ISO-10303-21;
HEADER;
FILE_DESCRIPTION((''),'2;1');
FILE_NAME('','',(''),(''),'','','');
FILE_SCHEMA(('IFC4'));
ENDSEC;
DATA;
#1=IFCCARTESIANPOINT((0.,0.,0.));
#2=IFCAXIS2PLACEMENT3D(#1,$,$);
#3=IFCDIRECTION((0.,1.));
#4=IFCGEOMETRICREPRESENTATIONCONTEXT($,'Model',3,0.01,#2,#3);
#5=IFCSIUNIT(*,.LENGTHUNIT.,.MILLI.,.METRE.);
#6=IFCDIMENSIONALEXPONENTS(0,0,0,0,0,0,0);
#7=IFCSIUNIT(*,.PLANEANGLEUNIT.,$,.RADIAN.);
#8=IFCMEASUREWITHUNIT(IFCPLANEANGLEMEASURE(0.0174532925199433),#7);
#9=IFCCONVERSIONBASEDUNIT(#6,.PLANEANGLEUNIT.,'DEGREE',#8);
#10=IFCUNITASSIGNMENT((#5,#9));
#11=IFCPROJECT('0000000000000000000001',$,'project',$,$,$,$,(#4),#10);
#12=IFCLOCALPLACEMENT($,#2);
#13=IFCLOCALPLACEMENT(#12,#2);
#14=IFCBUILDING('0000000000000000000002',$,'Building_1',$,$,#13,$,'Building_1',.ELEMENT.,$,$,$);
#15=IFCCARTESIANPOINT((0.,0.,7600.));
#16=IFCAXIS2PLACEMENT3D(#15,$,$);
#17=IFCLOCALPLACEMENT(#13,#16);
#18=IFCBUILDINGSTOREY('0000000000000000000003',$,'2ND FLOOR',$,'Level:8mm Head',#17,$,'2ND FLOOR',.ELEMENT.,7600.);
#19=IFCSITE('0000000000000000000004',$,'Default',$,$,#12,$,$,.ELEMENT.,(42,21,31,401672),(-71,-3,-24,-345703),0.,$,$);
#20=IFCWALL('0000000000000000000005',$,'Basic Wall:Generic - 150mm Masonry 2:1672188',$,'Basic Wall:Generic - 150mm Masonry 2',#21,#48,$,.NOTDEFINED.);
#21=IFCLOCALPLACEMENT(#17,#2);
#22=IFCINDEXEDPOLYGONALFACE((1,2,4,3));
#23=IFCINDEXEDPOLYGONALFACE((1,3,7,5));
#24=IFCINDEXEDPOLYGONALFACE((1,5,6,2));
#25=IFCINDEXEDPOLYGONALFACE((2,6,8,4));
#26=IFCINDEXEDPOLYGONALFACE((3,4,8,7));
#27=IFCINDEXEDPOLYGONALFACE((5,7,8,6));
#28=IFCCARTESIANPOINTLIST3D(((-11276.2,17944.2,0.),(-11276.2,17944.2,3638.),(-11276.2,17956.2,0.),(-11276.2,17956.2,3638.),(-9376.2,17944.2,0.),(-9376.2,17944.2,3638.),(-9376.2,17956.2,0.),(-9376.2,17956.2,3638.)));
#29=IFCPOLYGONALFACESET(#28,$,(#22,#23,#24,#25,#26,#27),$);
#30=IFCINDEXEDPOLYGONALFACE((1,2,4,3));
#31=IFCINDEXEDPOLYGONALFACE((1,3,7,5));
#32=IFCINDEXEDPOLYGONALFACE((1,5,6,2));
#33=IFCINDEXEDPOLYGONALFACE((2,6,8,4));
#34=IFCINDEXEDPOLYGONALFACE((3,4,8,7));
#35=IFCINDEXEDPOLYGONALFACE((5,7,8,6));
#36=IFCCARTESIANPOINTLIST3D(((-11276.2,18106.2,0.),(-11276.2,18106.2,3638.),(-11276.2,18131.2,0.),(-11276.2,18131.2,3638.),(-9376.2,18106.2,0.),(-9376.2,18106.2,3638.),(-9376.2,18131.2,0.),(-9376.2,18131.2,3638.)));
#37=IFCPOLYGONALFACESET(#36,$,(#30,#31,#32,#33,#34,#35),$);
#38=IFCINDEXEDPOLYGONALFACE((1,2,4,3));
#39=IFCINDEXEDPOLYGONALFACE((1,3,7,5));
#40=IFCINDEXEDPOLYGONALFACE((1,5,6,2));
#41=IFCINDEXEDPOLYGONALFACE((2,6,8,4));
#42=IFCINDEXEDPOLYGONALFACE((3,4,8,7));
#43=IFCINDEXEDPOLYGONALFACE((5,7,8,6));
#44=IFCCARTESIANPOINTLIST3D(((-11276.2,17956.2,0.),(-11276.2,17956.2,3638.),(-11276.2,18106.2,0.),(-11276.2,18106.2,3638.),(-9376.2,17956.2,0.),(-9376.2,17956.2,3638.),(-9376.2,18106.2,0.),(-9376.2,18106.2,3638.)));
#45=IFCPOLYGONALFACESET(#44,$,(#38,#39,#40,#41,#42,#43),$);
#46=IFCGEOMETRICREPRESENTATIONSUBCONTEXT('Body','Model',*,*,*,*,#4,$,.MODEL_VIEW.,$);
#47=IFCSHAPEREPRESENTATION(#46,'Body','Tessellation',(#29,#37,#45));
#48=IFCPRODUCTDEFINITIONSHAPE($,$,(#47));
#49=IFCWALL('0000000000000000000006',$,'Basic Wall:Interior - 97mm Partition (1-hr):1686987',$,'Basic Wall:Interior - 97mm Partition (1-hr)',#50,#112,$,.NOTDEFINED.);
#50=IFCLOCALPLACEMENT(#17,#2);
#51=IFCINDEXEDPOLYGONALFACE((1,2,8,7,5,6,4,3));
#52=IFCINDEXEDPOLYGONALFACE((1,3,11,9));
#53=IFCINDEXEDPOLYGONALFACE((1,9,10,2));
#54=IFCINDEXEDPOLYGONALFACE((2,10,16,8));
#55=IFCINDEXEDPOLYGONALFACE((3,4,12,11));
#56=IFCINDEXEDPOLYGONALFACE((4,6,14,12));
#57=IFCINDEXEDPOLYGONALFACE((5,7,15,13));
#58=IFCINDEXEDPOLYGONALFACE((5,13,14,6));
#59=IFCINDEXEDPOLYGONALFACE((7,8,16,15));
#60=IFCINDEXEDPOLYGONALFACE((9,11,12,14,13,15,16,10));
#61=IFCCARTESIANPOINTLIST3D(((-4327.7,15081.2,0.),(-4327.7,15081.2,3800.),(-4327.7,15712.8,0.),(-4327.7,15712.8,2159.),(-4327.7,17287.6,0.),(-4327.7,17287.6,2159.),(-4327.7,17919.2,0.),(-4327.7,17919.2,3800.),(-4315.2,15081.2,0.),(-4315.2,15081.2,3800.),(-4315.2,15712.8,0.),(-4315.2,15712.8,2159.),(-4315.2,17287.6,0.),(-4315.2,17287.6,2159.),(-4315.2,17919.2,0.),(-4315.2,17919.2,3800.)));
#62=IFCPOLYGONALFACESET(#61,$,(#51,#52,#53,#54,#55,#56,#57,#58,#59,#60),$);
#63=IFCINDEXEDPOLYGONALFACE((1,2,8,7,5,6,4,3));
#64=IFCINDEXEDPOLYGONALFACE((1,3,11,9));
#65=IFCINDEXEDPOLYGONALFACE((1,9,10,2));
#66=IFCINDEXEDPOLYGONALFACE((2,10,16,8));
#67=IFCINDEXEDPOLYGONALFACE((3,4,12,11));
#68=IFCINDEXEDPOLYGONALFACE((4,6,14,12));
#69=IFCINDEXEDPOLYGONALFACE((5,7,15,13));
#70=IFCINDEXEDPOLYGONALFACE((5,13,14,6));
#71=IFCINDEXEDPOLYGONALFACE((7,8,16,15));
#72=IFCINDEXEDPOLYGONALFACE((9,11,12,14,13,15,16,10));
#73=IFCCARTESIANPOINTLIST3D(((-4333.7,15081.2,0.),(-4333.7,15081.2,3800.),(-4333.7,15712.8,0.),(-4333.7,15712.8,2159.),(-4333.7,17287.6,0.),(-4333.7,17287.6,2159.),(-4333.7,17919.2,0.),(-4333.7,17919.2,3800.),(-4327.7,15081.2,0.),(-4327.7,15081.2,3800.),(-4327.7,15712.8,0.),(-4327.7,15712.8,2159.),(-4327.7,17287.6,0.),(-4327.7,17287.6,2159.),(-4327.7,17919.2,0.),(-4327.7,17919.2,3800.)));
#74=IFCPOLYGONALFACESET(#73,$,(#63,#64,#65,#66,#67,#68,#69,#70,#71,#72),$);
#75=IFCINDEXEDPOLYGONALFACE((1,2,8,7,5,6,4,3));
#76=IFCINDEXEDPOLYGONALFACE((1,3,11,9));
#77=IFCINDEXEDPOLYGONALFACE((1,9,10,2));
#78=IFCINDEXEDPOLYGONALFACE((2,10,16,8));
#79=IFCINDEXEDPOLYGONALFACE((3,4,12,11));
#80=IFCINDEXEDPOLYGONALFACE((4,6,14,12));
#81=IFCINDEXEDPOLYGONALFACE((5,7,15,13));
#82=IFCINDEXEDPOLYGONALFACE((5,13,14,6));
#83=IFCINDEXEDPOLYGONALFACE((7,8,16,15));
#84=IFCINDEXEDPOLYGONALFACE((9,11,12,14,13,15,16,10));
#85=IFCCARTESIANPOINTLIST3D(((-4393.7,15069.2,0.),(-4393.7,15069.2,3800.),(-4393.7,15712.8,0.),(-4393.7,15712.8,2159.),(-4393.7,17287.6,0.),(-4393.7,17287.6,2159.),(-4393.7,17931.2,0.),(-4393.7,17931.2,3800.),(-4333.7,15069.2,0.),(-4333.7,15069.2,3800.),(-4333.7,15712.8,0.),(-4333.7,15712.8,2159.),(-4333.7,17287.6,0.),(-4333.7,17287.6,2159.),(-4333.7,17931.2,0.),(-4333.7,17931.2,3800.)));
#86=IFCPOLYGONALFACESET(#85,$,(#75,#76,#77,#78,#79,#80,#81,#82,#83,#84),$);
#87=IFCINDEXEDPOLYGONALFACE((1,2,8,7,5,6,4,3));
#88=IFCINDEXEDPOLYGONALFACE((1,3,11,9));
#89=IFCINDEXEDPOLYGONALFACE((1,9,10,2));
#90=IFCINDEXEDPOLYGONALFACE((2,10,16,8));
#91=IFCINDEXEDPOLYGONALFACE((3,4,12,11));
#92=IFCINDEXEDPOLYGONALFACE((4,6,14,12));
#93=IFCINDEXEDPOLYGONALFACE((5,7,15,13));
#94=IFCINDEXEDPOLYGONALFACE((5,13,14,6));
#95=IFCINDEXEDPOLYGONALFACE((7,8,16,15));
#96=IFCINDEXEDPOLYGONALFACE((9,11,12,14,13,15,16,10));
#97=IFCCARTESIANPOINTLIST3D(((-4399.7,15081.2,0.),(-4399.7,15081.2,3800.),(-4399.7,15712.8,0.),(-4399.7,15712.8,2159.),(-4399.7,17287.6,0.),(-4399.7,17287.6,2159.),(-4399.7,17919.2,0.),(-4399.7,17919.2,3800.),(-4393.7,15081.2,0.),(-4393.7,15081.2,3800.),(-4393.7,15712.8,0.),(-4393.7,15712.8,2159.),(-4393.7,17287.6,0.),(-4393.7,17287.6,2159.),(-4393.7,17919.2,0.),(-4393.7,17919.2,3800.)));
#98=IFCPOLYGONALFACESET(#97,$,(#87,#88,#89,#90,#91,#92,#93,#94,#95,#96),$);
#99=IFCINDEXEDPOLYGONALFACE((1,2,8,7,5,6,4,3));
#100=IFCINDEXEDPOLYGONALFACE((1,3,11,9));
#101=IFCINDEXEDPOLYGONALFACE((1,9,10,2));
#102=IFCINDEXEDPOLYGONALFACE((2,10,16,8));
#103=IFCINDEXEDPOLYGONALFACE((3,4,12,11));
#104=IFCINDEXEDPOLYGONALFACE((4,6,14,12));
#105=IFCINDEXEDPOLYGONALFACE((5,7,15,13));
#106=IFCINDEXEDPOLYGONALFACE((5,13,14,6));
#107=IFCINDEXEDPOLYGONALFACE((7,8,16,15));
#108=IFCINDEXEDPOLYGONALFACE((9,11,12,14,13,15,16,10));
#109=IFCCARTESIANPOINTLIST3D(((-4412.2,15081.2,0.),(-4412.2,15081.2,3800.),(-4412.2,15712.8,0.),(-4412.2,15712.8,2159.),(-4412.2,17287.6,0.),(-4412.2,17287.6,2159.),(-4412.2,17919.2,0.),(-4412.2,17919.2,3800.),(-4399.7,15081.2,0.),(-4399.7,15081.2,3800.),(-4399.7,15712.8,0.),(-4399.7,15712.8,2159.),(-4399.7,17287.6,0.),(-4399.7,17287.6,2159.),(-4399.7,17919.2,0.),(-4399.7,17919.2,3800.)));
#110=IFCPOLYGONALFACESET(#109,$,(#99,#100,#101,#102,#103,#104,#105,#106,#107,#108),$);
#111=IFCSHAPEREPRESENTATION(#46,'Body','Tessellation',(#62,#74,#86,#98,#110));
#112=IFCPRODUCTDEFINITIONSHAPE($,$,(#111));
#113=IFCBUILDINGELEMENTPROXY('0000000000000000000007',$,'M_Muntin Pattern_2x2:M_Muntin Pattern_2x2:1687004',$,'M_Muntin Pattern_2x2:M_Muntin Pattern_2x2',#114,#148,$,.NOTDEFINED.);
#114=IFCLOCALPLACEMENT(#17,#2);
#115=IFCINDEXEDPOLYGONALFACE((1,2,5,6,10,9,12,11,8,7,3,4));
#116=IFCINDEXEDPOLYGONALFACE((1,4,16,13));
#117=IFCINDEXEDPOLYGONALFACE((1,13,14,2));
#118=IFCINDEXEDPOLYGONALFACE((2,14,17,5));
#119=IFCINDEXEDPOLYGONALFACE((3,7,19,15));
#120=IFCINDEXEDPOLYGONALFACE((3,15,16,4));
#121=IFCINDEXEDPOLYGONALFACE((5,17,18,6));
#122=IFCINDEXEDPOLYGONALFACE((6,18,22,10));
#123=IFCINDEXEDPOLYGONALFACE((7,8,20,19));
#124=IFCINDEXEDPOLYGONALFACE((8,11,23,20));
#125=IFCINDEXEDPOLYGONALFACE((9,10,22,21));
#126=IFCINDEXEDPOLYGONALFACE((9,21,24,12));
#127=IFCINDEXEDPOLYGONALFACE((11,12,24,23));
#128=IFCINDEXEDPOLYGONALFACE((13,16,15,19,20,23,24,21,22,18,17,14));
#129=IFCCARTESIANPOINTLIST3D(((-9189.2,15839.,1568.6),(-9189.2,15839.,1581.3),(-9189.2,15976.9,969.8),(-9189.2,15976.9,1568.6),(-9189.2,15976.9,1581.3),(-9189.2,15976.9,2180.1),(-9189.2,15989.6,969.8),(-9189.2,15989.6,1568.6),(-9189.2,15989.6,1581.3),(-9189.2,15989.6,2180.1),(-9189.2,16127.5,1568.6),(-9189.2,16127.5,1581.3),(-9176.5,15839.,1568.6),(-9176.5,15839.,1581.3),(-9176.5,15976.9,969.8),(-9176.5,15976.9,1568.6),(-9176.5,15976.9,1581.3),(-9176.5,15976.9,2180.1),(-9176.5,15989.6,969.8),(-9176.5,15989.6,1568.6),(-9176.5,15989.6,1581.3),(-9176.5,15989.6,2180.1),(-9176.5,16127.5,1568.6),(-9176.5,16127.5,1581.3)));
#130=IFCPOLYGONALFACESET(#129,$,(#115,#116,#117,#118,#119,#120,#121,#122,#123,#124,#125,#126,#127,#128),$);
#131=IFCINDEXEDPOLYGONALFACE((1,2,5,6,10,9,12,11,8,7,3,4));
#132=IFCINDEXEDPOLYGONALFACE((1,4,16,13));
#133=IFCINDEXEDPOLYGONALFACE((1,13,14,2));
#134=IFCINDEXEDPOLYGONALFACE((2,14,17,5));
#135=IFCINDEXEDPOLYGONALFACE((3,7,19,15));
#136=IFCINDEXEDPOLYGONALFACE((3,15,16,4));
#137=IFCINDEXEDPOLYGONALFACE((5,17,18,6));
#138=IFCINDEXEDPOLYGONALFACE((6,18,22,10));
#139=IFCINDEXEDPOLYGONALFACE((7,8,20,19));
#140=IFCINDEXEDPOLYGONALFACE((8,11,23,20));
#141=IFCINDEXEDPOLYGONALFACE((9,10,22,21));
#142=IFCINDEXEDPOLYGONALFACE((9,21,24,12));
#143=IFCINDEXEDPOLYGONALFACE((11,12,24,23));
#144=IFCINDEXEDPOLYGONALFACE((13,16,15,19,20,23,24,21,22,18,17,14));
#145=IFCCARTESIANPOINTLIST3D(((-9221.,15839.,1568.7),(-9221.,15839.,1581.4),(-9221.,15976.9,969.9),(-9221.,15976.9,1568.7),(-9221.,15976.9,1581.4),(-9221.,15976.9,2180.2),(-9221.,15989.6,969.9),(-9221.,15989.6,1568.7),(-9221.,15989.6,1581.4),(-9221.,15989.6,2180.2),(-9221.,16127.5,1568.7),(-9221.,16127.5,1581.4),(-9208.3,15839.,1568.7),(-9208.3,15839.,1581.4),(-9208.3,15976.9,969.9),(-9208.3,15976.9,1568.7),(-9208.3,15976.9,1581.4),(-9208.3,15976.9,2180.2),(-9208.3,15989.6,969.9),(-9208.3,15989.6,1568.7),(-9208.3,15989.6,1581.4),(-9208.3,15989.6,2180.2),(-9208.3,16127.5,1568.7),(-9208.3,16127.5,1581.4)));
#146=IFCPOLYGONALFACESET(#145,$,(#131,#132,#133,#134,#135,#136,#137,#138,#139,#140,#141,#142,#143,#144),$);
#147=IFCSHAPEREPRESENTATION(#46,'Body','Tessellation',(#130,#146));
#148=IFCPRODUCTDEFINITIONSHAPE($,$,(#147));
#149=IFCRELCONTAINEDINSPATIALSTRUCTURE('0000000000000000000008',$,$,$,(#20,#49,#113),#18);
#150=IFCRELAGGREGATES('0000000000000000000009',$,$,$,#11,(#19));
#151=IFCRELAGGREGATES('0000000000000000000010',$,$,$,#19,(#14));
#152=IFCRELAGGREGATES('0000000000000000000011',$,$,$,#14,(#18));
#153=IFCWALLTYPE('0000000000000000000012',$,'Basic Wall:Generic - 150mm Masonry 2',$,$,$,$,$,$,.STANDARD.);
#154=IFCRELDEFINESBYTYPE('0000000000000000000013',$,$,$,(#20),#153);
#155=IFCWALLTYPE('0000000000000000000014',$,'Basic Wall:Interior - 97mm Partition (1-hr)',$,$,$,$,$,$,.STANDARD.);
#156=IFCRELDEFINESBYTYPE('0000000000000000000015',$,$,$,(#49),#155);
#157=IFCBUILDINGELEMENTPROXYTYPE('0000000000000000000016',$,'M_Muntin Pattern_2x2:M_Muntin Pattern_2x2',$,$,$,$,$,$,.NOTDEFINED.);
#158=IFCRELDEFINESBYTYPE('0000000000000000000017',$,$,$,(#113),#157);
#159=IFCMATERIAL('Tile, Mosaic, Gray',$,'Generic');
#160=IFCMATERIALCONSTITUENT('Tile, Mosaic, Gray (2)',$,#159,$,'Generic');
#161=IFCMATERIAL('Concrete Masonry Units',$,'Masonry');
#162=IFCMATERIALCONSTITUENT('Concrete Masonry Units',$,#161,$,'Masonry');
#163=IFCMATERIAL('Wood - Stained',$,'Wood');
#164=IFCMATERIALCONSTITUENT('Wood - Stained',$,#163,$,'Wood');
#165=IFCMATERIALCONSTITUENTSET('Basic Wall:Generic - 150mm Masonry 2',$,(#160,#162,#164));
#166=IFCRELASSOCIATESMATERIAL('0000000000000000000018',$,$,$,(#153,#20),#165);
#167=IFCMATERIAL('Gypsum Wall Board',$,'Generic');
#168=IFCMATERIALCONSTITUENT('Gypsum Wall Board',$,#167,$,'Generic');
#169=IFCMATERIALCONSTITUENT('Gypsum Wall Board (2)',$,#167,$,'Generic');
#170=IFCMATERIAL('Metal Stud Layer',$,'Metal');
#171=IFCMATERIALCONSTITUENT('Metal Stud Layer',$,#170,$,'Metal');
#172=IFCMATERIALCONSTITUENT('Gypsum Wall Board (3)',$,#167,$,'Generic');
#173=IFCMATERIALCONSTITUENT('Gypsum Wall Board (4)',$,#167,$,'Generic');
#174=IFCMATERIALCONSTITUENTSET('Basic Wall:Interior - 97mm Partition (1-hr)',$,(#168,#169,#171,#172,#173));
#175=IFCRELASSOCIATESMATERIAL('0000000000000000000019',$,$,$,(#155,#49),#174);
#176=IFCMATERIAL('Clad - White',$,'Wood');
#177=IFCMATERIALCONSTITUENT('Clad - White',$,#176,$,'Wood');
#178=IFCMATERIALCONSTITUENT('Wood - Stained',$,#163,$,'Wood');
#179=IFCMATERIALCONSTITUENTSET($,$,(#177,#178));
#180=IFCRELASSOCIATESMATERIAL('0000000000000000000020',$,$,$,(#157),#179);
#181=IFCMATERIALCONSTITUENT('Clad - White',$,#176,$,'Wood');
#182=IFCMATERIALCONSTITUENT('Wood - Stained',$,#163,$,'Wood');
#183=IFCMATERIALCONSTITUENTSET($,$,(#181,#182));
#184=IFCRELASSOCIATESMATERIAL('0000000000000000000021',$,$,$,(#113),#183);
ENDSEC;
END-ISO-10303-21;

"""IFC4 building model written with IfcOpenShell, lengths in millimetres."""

from ifc_helpers import new_model, entity, si_unit, converted_unit, direction, frame, origin, place, context, subcontext, project, spatial, indexed_curve, outline, extrude, source, transform, mapped, material, constituent, constituent_set, type_object, type_shapes, element, save


model = new_model("IFC4")

# Units and contexts
model_context = context("Model", 3, precision=0.01, world=origin(), true_north=direction((0.0, 1.0)))
body_context = subcontext(model_context, "Body", "Model", "MODEL_VIEW")
ifc_project = project(units=[si_unit("LENGTHUNIT", "METRE", prefix="MILLI"), converted_unit("PLANEANGLEUNIT", "DEGREE", entity("IfcPlaneAngleMeasure", 0.0174532925199433), si_unit("PLANEANGLEUNIT", "RADIAN"), dimensions=[0, 0, 0, 0, 0, 0, 0])], contexts=[model_context])

# Site, building, storey
site_placement = place(None, origin())
site = spatial("IfcSite", under=ifc_project, at=site_placement, Name="Default", CompositionType="ELEMENT", RefLatitude=(42, 21, 31, 401672), RefLongitude=(-71, -3, -24, -345703), RefElevation=0.0)
building_placement = place(site_placement, origin())
building = spatial("IfcBuilding", under=site, at=building_placement, Name="Building_1", LongName="Building_1", CompositionType="ELEMENT")
storey_placement = place(building_placement, frame((0.0, 0.0, 7600.0)))
storey = spatial("IfcBuildingStorey", under=building, at=storey_placement, Name="2ND FLOOR", ObjectType="Level:8mm Head", LongName="2ND FLOOR", CompositionType="ELEMENT", Elevation=7600.0)

# Shared definitions
ifc_material_1 = material(Name="Tile, Mosaic, Gray", Category="Generic")
ifc_constituent_1 = constituent(ifc_material_1, Name="Tile, Mosaic, Gray (2)", Category="Generic")
ifc_material_2 = material(Name="Concrete Masonry Units", Category="Masonry")
ifc_constituent_2 = constituent(ifc_material_2, Name="Concrete Masonry Units", Category="Masonry")
ifc_material_3 = material(Name="Wood - Stained", Category="Wood")
ifc_constituent_3 = constituent(ifc_material_3, Name="Wood - Stained", Category="Wood")
ifc_constituent_set_1 = constituent_set(constituents=[ifc_constituent_1, ifc_constituent_2, ifc_constituent_3], Name="Basic Wall:Generic - 150mm Masonry 2")
wall_type_1 = type_object("IfcWallType", Name="Basic Wall:Generic - 150mm Masonry 2", PredefinedType="STANDARD", material=ifc_constituent_set_1)

# Wall
wall_1_placement = place(storey_placement, frame((-11276.2, 18037.7, 0.0)))
element("IfcWall", 1, at=wall_1_placement, inside=storey, type_object=wall_type_1, material=ifc_constituent_set_1, Name="Basic Wall:Generic - 150mm Masonry 2:1672188", ObjectType="Basic Wall:Generic - 150mm Masonry 2", PredefinedType="NOTDEFINED", context=body_context, shape_type="SweptSolid", body=[
    extrude(outline(indexed_curve([(-6.0, -950.0), (6.0, -950.0), (6.0, 950.0), (-6.0, 950.0), (-6.0, -950.0)], self_intersect=False)), frame((950.0, -87.5, 0.0), z_axis=(0.0, 0.0, 1.0), x_axis=(0.0, 1.0, 0.0)), (0.0, 0.0, 1.0), 3638.0),
    extrude(outline(indexed_curve([(-12.5, -950.0), (12.5, -950.0), (12.5, 950.0), (-12.5, 950.0), (-12.5, -950.0)], self_intersect=False)), frame((950.0, 81.0, 0.0), z_axis=(0.0, 0.0, 1.0), x_axis=(0.0, -1.0, 0.0)), (0.0, 0.0, 1.0), 3638.0),
    extrude(outline(indexed_curve([(-950.0, -75.0), (950.0, -75.0), (950.0, 75.0), (-950.0, 75.0), (-950.0, -75.0)], self_intersect=False)), frame((950.0, -6.5, 0.0)), (0.0, 0.0, 1.0), 3638.0),
])

# Wall, opening
ifc_material_4 = material(Name="Gypsum Wall Board", Category="Generic")
ifc_constituent_4 = constituent(ifc_material_4, Name="Gypsum Wall Board", Category="Generic")
ifc_constituent_5 = constituent(ifc_material_4, Name="Gypsum Wall Board (2)", Category="Generic")
ifc_material_5 = material(Name="Metal Stud Layer", Category="Metal")
ifc_constituent_6 = constituent(ifc_material_5, Name="Metal Stud Layer", Category="Metal")
ifc_constituent_7 = constituent(ifc_material_4, Name="Gypsum Wall Board (3)", Category="Generic")
ifc_constituent_8 = constituent(ifc_material_4, Name="Gypsum Wall Board (4)", Category="Generic")
ifc_constituent_set_2 = constituent_set(constituents=[ifc_constituent_4, ifc_constituent_5, ifc_constituent_6, ifc_constituent_7, ifc_constituent_8], Name="Basic Wall:Interior - 97mm Partition (1-hr)")
wall_type_2 = type_object("IfcWallType", Name="Basic Wall:Interior - 97mm Partition (1-hr)", PredefinedType="STANDARD", material=ifc_constituent_set_2)
wall_2_placement = place(storey_placement, frame((-4363.7, 15081.2, 0.0), z_axis=(0.0, 0.0, 1.0), x_axis=(0.0, 1.0, 0.0)))
wall_2 = element("IfcWall", 2, at=wall_2_placement, inside=storey, type_object=wall_type_2, material=ifc_constituent_set_2, Name="Basic Wall:Interior - 97mm Partition (1-hr):1686987", ObjectType="Basic Wall:Interior - 97mm Partition (1-hr)", PredefinedType="NOTDEFINED", context=body_context, shape_type="SweptSolid", body=[
    extrude(outline(indexed_curve([(-1489.8, -1419.0), (2310.2, -1419.0), (2310.2, 1419.0), (-1489.8, 1419.0), (-1489.8, 787.4), (669.2, 787.4), (669.2, -787.4), (-1489.8, -787.4), (-1489.8, -1419.0)], self_intersect=False)), frame((1419.0, -36.0, 1489.8), z_axis=(0.0, -1.0, 0.0), x_axis=(0.0, 0.0, 1.0)), (0.0, 0.0, 1.0), 12.5),
    extrude(outline(indexed_curve([(-1489.8, -1419.0), (2310.2, -1419.0), (2310.2, 1419.0), (-1489.8, 1419.0), (-1489.8, 787.4), (669.2, 787.4), (669.2, -787.4), (-1489.8, -787.4), (-1489.8, -1419.0)], self_intersect=False)), frame((1419.0, -30.0, 1489.8), z_axis=(0.0, -1.0, 0.0), x_axis=(0.0, 0.0, 1.0)), (0.0, 0.0, 1.0), 6.0),
    extrude(outline(indexed_curve([(-1489.8, -1431.0), (2310.2, -1431.0), (2310.2, 1431.0), (-1489.8, 1431.0), (-1489.8, 787.4), (669.2, 787.4), (669.2, -787.4), (-1489.8, -787.4), (-1489.8, -1431.0)], self_intersect=False)), frame((1419.0, 30.0, 1489.8), z_axis=(0.0, -1.0, 0.0), x_axis=(0.0, 0.0, 1.0)), (0.0, 0.0, 1.0), 60.0),
    extrude(outline(indexed_curve([(-1489.8, -1419.0), (2310.2, -1419.0), (2310.2, 1419.0), (-1489.8, 1419.0), (-1489.8, 787.4), (669.2, 787.4), (669.2, -787.4), (-1489.8, -787.4), (-1489.8, -1419.0)], self_intersect=False)), frame((1419.0, 36.0, 1489.8), z_axis=(0.0, -1.0, 0.0), x_axis=(0.0, 0.0, 1.0)), (0.0, 0.0, 1.0), 6.0),
    extrude(outline(indexed_curve([(-2310.2, -1419.0), (1489.8, -1419.0), (1489.8, -787.4), (-669.2, -787.4), (-669.2, 787.4), (1489.8, 787.4), (1489.8, 1419.0), (-2310.2, 1419.0), (-2310.2, -1419.0)], self_intersect=False)), frame((1419.0, 48.5, 1489.8), z_axis=(0.0, -1.0, 0.0), x_axis=(0.0, 0.0, -1.0)), (0.0, 0.0, 1.0), 12.5),
])
opening_1_placement = place(wall_2_placement, frame((2206.4, 48.5, 0.0)))
element("IfcOpeningElement", 3, at=opening_1_placement, cuts=wall_2, PredefinedType="OPENING", context=body_context, shape_type="SweptSolid", body=[
    extrude(outline(indexed_curve([(0.0, 1574.8), (0.0, 0.0), (2159.0, 0.0), (2159.0, 1574.8), (0.0, 1574.8)], self_intersect=False)), frame((0.0, 0.0, 0.0), z_axis=(0.0, -1.0, 0.0), x_axis=(0.0, 0.0, 1.0)), (0.0, 0.0, 1.0), 97.0),
])

# Building element proxy
ifc_material_6 = material(Name="Clad - White", Category="Wood")
ifc_constituent_9 = constituent(ifc_material_6, Name="Clad - White", Category="Wood")
ifc_constituent_10 = constituent(ifc_material_3, Name="Wood - Stained", Category="Wood")
ifc_constituent_set_3 = constituent_set(constituents=[ifc_constituent_9, ifc_constituent_10])
ifc_constituent_11 = constituent(ifc_material_6, Name="Clad - White", Category="Wood")
ifc_constituent_12 = constituent(ifc_material_3, Name="Wood - Stained", Category="Wood")
ifc_constituent_set_4 = constituent_set(constituents=[ifc_constituent_11, ifc_constituent_12])
building_element_proxy_type_1 = type_object("IfcBuildingElementProxyType", Name="M_Muntin Pattern_2x2:M_Muntin Pattern_2x2", PredefinedType="NOTDEFINED", material=ifc_constituent_set_4)
shared_shape_1 = source(origin(), body_context, "Body", "SweptSolid", [
    extrude(outline(indexed_curve([(6.4, -6.4), (605.1, -6.4), (605.1, 6.3), (6.4, 6.3), (6.4, 144.2), (-6.3, 144.2), (-6.3, 6.3), (-605.2, 6.3), (-605.2, -6.4), (-6.3, -6.4), (-6.3, -144.2), (6.4, -144.2), (6.4, -6.4)], self_intersect=False)), frame((0.0, -22.2, 605.1), z_axis=(0.0, 1.0, 0.0), x_axis=(0.0, 0.0, 1.0)), (0.0, 0.0, 1.0), 12.7),
    extrude(outline(indexed_curve([(6.4, -6.4), (605.2, -6.4), (605.2, 6.3), (6.4, 6.3), (6.4, 144.2), (-6.3, 144.2), (-6.3, 6.3), (-605.2, 6.3), (-605.2, -6.4), (-6.3, -6.4), (-6.3, -144.2), (6.4, -144.2), (6.4, -6.4)], self_intersect=False)), frame((0.0, 9.5, 605.2), z_axis=(0.0, 1.0, 0.0), x_axis=(0.0, 0.0, 1.0)), (0.0, 0.0, 1.0), 12.7),
])
type_shapes(building_element_proxy_type_1, [shared_shape_1])
proxy_1_placement = place(storey_placement, frame((-9198.7, 15983.3, 969.9), z_axis=(0.0, 0.0, 1.0), x_axis=(0.0, 1.0, 0.0)))
element("IfcBuildingElementProxy", 4, at=proxy_1_placement, inside=storey, type_object=building_element_proxy_type_1, material=ifc_constituent_set_3, Name="M_Muntin Pattern_2x2:M_Muntin Pattern_2x2:1687004", ObjectType="M_Muntin Pattern_2x2:M_Muntin Pattern_2x2", PredefinedType="NOTDEFINED", context=body_context, shape_type="MappedRepresentation", body=[
    mapped(shared_shape_1, transform((0.0, 0.0, 0.0), scale=1.0)),
])

save(model, "model.ifc")
